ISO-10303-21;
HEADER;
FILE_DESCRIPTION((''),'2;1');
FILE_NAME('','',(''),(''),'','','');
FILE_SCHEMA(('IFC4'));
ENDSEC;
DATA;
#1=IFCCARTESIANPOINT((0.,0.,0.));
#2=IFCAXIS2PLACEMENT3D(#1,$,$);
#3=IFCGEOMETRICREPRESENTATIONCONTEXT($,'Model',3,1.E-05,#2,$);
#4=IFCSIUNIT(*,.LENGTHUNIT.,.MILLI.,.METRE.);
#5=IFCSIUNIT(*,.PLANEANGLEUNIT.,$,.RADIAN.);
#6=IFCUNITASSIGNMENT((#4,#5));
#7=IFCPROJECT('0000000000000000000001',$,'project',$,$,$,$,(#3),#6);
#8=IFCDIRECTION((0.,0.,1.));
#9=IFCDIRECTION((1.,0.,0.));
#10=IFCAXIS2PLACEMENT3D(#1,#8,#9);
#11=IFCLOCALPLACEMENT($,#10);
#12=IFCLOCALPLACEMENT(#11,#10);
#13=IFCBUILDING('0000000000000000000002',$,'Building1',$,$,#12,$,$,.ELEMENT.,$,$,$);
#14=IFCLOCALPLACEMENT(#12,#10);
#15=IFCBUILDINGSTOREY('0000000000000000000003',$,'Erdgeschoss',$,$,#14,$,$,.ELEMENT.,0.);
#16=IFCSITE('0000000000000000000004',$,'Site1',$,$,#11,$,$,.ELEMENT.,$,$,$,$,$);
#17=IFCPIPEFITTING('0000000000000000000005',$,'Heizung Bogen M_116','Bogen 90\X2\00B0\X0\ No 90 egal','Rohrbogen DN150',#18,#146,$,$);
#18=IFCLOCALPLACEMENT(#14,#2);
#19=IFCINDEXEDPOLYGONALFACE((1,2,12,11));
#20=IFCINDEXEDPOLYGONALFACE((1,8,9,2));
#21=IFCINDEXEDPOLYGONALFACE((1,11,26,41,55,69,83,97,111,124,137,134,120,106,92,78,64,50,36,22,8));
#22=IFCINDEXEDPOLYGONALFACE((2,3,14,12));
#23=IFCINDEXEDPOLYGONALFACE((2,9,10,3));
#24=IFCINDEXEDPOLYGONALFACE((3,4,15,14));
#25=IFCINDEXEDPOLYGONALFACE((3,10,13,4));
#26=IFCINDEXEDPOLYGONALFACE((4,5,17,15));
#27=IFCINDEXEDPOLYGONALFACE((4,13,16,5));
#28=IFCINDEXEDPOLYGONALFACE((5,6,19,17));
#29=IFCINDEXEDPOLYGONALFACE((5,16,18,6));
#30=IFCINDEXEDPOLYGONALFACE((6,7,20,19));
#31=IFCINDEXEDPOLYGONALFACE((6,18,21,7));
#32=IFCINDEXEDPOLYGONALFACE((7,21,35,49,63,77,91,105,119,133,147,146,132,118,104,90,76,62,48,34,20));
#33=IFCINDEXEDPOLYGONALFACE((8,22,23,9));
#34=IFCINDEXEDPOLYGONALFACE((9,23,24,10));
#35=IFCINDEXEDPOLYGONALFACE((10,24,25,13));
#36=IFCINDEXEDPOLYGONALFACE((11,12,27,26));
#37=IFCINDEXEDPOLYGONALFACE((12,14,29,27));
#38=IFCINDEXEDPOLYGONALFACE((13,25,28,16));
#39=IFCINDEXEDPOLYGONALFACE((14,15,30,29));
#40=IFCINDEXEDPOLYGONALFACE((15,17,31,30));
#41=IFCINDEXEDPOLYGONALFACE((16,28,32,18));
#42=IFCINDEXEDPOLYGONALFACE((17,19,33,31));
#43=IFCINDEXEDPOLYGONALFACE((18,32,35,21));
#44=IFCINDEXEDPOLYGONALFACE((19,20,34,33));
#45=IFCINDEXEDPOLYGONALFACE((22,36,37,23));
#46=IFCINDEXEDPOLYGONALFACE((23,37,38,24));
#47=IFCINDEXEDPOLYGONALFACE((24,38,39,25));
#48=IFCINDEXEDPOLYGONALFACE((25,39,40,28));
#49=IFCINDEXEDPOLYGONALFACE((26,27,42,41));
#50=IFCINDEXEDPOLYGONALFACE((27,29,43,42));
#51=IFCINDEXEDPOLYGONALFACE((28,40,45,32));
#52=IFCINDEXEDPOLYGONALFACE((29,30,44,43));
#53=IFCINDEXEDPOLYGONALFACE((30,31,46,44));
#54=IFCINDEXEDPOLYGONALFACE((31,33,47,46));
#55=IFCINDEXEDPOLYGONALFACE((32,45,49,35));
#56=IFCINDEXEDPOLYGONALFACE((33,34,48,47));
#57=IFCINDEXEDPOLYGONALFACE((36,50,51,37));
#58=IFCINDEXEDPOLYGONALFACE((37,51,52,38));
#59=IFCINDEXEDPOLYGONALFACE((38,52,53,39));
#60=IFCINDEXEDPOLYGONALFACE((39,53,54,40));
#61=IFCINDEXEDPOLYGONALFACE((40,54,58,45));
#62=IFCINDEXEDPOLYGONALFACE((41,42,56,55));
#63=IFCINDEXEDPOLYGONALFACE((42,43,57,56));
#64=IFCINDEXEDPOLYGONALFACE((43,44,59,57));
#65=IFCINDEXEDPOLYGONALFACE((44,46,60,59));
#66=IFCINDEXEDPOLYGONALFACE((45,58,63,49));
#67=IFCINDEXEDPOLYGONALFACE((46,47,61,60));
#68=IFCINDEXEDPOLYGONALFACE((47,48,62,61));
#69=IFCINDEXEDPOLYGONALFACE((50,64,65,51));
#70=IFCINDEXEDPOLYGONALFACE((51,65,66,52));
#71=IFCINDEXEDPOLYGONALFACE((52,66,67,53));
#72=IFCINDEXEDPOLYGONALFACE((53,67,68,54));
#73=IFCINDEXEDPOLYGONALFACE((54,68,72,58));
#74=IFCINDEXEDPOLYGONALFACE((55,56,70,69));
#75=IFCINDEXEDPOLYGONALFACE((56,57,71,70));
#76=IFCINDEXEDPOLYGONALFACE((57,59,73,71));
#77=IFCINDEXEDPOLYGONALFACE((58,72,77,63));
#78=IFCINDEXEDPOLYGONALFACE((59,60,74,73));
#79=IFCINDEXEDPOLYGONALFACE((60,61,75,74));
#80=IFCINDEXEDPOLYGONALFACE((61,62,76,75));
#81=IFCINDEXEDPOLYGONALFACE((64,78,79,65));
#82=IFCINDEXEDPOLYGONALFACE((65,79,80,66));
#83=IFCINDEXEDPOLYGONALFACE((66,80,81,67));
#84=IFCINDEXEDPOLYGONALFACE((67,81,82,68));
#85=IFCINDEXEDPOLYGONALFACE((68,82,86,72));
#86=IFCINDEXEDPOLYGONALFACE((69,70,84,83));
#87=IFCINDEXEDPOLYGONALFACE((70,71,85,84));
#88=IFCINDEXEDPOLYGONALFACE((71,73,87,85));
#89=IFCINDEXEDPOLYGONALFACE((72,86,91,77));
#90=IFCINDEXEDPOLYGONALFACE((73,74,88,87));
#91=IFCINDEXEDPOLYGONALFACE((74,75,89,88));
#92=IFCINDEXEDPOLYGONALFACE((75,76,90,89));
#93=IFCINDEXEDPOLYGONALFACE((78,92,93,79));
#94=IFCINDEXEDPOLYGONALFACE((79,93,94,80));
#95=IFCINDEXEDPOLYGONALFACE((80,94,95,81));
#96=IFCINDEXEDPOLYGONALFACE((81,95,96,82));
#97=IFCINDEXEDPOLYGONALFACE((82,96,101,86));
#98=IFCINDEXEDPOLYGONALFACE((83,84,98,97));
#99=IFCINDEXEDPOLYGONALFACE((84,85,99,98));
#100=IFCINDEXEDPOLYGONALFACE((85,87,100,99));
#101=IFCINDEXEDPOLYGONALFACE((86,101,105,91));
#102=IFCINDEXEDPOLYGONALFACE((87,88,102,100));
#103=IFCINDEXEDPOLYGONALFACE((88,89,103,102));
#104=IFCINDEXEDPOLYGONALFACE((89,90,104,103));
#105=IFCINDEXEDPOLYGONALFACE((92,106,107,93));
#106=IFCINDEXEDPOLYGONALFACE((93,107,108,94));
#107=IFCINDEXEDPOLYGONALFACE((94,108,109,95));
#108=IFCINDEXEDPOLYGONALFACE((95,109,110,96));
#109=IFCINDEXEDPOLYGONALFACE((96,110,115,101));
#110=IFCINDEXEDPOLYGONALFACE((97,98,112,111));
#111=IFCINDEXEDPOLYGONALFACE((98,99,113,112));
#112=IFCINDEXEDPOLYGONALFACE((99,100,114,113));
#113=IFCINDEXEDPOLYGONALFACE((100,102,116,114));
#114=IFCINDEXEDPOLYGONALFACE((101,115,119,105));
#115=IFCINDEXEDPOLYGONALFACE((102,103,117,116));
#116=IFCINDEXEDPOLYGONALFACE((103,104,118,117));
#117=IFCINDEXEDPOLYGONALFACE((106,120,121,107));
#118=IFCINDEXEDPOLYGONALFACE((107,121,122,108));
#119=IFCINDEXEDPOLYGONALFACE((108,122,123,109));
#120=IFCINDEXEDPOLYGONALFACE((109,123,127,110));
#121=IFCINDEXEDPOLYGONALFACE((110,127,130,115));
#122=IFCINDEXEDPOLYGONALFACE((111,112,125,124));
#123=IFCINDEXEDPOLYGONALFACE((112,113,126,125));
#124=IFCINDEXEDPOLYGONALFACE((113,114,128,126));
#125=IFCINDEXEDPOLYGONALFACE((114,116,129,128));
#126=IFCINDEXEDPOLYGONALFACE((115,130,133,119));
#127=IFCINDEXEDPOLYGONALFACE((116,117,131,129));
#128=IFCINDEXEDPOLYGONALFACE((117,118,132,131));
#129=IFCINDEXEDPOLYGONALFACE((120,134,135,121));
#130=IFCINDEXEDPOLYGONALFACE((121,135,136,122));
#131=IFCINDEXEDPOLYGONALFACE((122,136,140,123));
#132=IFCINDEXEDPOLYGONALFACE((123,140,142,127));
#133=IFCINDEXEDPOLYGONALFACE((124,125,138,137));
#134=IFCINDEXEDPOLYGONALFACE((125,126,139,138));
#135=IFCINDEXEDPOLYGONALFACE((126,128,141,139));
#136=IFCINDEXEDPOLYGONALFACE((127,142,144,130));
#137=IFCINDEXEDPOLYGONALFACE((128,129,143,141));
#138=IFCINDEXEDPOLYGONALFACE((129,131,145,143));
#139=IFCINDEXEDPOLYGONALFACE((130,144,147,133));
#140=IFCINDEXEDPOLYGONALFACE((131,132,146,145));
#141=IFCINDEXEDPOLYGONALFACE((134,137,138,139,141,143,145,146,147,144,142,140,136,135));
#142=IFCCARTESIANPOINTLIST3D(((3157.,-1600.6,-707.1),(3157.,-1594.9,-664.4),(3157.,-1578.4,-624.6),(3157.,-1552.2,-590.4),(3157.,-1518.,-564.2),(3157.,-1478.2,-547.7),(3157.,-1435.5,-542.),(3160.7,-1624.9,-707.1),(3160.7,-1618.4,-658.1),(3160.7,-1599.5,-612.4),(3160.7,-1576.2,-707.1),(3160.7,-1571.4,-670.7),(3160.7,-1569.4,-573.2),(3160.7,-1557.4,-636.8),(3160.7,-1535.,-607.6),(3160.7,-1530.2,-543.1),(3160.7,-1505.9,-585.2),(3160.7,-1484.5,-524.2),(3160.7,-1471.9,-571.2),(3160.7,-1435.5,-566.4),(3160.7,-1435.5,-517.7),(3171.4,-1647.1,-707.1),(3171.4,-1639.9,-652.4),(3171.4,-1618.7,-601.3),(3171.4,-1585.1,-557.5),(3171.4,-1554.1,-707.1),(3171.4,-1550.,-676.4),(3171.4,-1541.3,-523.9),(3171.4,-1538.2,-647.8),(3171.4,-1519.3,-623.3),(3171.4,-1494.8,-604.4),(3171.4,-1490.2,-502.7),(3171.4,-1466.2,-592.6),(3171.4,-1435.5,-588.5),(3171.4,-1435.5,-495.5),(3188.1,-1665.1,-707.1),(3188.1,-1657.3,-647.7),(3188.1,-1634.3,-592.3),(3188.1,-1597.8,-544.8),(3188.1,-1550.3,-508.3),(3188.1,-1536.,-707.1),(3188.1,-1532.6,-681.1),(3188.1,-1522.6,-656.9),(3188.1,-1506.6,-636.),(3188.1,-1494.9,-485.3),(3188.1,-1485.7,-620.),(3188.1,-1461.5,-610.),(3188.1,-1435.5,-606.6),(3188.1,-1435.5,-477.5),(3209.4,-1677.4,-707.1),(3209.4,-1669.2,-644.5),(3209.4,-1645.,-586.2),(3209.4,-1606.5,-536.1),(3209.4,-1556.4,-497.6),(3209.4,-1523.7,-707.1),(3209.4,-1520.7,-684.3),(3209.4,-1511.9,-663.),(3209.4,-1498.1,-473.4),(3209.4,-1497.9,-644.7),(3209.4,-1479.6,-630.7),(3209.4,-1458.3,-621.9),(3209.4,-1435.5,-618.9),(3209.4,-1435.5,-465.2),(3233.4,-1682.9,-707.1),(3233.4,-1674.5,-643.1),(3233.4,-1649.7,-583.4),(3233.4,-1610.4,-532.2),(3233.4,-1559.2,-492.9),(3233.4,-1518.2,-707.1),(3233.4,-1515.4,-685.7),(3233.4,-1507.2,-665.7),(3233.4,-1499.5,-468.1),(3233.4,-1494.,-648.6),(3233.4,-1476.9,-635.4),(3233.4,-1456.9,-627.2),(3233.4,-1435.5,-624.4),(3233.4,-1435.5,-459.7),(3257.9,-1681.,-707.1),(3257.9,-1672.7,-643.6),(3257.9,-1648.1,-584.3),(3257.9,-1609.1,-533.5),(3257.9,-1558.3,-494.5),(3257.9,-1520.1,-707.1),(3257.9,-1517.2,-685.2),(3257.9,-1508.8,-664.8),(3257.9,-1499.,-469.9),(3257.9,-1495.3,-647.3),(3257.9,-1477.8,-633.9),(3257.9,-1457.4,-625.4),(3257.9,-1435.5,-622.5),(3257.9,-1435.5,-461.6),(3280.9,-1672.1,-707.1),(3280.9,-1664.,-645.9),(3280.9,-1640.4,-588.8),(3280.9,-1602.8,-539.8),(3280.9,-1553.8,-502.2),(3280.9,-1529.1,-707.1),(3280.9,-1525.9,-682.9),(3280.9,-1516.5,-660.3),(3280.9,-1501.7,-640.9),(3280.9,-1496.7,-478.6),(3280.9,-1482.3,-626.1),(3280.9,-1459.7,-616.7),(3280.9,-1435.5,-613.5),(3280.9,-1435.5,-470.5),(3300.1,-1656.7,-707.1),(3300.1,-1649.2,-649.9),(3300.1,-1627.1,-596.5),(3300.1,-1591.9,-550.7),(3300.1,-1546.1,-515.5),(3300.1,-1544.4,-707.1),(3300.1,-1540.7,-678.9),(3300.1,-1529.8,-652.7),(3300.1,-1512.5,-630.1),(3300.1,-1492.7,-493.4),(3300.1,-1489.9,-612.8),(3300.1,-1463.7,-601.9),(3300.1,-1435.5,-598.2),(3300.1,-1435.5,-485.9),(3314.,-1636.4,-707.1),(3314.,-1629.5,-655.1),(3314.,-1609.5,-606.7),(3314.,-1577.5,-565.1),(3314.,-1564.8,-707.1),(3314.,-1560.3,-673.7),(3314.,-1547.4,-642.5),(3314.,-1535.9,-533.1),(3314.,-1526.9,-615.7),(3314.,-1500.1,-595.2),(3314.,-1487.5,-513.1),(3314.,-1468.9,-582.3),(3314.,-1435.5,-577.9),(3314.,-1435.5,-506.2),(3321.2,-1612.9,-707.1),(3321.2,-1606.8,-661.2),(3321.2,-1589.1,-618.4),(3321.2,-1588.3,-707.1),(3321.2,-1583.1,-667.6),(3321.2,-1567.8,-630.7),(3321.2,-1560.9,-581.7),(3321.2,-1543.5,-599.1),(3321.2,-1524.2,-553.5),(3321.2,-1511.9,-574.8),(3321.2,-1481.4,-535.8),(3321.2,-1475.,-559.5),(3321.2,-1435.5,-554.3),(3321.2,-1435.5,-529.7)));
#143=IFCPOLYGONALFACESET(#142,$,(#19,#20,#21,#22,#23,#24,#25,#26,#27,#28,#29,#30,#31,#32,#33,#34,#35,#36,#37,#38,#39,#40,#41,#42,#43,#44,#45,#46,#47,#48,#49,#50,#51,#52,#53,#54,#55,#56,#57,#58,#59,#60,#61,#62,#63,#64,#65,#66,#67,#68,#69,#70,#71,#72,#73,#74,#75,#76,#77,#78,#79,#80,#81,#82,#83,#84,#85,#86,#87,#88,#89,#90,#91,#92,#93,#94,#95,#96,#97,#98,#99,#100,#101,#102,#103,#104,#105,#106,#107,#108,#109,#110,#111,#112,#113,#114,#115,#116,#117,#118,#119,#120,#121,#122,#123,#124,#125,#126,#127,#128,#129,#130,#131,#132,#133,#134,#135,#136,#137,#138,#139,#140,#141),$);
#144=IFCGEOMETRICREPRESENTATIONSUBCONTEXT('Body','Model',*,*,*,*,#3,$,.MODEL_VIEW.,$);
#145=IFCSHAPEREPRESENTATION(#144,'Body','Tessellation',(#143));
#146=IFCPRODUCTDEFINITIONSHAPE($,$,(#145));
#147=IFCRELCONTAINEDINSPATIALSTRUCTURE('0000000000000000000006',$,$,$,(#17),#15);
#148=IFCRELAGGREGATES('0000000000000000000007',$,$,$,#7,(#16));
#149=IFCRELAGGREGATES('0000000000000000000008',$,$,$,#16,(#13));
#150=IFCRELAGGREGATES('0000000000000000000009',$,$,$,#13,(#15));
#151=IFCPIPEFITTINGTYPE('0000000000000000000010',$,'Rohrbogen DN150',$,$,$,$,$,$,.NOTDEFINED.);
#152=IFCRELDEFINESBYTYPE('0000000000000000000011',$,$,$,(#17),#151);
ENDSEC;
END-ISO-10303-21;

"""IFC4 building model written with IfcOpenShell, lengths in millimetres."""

from ifc_helpers import new_model, entity, si_unit, frame, origin, origin_with_axes, place, context, subcontext, project, spatial, source, transform, mapped, type_object, element, save


model = new_model("IFC4")

# Units and contexts
model_context = context("Model", 3, precision=1e-05, world=origin())
body_context = subcontext(model_context, "Body", "Model", "MODEL_VIEW")
ifc_project = project(units=[si_unit("LENGTHUNIT", "METRE", prefix="MILLI"), si_unit("PLANEANGLEUNIT", "RADIAN")], contexts=[model_context])

# Site, building, storey
site_placement = place(None, origin_with_axes())
site = spatial("IfcSite", under=ifc_project, at=site_placement, Name="Site1", CompositionType="ELEMENT")
building_placement = place(site_placement, origin_with_axes())
building = spatial("IfcBuilding", under=site, at=building_placement, Name="Building1", CompositionType="ELEMENT")
storey_placement = place(building_placement, origin_with_axes())
storey = spatial("IfcBuildingStorey", under=building, at=storey_placement, Name="Erdgeschoss", CompositionType="ELEMENT", Elevation=0.0)

# Pipe fitting
pipe_fitting_type_1 = type_object("IfcPipeFittingType", Name="Rohrbogen DN150", PredefinedType="NOTDEFINED")
shared_shape_1 = source(origin_with_axes(), body_context, "Body", "SolidModel", [
    entity("IfcRevolvedAreaSolid", entity("IfcCircleProfileDef", "AREA", None, entity("IfcAxis2Placement2D", entity("IfcCartesianPoint", [0.0, 0.0]), entity("IfcDirection", [1.0, 0.0])), 82.5), entity("IfcAxis2Placement3D", entity("IfcCartesianPoint", [-123.8, 0.0, 41.3]), entity("IfcDirection", [1.0, 0.0, 0.0]), entity("IfcDirection", [0.0, -1.0, 0.0])), entity("IfcAxis1Placement", entity("IfcCartesianPoint", [0.0, 165.1, 0.0]), entity("IfcDirection", [-1.0, 0.0, 0.0])), 1.570796),
])
pipe_fitting_1_placement = place(storey_placement, frame((3239.6, -1559.3, -583.3), z_axis=(0.0, 0.0, 1.0), x_axis=(1.0, 0.0, 0.0)))
element("IfcPipeFitting", 1, at=pipe_fitting_1_placement, inside=storey, type_object=pipe_fitting_type_1, Name="Heizung Bogen M_116", Description="Bogen 90° No 90 egal", ObjectType="Rohrbogen DN150", context=body_context, shape_type="MappedRepresentation", body=[
    mapped(shared_shape_1, transform((0.0, 0.0, 0.0), x_axis=(0.0, -1.0, 0.0), y_axis=(1.0, 0.0, 0.0), z_axis=(0.0, 0.0, 1.0), scale=1.0)),
])

save(model, "model.ifc")
